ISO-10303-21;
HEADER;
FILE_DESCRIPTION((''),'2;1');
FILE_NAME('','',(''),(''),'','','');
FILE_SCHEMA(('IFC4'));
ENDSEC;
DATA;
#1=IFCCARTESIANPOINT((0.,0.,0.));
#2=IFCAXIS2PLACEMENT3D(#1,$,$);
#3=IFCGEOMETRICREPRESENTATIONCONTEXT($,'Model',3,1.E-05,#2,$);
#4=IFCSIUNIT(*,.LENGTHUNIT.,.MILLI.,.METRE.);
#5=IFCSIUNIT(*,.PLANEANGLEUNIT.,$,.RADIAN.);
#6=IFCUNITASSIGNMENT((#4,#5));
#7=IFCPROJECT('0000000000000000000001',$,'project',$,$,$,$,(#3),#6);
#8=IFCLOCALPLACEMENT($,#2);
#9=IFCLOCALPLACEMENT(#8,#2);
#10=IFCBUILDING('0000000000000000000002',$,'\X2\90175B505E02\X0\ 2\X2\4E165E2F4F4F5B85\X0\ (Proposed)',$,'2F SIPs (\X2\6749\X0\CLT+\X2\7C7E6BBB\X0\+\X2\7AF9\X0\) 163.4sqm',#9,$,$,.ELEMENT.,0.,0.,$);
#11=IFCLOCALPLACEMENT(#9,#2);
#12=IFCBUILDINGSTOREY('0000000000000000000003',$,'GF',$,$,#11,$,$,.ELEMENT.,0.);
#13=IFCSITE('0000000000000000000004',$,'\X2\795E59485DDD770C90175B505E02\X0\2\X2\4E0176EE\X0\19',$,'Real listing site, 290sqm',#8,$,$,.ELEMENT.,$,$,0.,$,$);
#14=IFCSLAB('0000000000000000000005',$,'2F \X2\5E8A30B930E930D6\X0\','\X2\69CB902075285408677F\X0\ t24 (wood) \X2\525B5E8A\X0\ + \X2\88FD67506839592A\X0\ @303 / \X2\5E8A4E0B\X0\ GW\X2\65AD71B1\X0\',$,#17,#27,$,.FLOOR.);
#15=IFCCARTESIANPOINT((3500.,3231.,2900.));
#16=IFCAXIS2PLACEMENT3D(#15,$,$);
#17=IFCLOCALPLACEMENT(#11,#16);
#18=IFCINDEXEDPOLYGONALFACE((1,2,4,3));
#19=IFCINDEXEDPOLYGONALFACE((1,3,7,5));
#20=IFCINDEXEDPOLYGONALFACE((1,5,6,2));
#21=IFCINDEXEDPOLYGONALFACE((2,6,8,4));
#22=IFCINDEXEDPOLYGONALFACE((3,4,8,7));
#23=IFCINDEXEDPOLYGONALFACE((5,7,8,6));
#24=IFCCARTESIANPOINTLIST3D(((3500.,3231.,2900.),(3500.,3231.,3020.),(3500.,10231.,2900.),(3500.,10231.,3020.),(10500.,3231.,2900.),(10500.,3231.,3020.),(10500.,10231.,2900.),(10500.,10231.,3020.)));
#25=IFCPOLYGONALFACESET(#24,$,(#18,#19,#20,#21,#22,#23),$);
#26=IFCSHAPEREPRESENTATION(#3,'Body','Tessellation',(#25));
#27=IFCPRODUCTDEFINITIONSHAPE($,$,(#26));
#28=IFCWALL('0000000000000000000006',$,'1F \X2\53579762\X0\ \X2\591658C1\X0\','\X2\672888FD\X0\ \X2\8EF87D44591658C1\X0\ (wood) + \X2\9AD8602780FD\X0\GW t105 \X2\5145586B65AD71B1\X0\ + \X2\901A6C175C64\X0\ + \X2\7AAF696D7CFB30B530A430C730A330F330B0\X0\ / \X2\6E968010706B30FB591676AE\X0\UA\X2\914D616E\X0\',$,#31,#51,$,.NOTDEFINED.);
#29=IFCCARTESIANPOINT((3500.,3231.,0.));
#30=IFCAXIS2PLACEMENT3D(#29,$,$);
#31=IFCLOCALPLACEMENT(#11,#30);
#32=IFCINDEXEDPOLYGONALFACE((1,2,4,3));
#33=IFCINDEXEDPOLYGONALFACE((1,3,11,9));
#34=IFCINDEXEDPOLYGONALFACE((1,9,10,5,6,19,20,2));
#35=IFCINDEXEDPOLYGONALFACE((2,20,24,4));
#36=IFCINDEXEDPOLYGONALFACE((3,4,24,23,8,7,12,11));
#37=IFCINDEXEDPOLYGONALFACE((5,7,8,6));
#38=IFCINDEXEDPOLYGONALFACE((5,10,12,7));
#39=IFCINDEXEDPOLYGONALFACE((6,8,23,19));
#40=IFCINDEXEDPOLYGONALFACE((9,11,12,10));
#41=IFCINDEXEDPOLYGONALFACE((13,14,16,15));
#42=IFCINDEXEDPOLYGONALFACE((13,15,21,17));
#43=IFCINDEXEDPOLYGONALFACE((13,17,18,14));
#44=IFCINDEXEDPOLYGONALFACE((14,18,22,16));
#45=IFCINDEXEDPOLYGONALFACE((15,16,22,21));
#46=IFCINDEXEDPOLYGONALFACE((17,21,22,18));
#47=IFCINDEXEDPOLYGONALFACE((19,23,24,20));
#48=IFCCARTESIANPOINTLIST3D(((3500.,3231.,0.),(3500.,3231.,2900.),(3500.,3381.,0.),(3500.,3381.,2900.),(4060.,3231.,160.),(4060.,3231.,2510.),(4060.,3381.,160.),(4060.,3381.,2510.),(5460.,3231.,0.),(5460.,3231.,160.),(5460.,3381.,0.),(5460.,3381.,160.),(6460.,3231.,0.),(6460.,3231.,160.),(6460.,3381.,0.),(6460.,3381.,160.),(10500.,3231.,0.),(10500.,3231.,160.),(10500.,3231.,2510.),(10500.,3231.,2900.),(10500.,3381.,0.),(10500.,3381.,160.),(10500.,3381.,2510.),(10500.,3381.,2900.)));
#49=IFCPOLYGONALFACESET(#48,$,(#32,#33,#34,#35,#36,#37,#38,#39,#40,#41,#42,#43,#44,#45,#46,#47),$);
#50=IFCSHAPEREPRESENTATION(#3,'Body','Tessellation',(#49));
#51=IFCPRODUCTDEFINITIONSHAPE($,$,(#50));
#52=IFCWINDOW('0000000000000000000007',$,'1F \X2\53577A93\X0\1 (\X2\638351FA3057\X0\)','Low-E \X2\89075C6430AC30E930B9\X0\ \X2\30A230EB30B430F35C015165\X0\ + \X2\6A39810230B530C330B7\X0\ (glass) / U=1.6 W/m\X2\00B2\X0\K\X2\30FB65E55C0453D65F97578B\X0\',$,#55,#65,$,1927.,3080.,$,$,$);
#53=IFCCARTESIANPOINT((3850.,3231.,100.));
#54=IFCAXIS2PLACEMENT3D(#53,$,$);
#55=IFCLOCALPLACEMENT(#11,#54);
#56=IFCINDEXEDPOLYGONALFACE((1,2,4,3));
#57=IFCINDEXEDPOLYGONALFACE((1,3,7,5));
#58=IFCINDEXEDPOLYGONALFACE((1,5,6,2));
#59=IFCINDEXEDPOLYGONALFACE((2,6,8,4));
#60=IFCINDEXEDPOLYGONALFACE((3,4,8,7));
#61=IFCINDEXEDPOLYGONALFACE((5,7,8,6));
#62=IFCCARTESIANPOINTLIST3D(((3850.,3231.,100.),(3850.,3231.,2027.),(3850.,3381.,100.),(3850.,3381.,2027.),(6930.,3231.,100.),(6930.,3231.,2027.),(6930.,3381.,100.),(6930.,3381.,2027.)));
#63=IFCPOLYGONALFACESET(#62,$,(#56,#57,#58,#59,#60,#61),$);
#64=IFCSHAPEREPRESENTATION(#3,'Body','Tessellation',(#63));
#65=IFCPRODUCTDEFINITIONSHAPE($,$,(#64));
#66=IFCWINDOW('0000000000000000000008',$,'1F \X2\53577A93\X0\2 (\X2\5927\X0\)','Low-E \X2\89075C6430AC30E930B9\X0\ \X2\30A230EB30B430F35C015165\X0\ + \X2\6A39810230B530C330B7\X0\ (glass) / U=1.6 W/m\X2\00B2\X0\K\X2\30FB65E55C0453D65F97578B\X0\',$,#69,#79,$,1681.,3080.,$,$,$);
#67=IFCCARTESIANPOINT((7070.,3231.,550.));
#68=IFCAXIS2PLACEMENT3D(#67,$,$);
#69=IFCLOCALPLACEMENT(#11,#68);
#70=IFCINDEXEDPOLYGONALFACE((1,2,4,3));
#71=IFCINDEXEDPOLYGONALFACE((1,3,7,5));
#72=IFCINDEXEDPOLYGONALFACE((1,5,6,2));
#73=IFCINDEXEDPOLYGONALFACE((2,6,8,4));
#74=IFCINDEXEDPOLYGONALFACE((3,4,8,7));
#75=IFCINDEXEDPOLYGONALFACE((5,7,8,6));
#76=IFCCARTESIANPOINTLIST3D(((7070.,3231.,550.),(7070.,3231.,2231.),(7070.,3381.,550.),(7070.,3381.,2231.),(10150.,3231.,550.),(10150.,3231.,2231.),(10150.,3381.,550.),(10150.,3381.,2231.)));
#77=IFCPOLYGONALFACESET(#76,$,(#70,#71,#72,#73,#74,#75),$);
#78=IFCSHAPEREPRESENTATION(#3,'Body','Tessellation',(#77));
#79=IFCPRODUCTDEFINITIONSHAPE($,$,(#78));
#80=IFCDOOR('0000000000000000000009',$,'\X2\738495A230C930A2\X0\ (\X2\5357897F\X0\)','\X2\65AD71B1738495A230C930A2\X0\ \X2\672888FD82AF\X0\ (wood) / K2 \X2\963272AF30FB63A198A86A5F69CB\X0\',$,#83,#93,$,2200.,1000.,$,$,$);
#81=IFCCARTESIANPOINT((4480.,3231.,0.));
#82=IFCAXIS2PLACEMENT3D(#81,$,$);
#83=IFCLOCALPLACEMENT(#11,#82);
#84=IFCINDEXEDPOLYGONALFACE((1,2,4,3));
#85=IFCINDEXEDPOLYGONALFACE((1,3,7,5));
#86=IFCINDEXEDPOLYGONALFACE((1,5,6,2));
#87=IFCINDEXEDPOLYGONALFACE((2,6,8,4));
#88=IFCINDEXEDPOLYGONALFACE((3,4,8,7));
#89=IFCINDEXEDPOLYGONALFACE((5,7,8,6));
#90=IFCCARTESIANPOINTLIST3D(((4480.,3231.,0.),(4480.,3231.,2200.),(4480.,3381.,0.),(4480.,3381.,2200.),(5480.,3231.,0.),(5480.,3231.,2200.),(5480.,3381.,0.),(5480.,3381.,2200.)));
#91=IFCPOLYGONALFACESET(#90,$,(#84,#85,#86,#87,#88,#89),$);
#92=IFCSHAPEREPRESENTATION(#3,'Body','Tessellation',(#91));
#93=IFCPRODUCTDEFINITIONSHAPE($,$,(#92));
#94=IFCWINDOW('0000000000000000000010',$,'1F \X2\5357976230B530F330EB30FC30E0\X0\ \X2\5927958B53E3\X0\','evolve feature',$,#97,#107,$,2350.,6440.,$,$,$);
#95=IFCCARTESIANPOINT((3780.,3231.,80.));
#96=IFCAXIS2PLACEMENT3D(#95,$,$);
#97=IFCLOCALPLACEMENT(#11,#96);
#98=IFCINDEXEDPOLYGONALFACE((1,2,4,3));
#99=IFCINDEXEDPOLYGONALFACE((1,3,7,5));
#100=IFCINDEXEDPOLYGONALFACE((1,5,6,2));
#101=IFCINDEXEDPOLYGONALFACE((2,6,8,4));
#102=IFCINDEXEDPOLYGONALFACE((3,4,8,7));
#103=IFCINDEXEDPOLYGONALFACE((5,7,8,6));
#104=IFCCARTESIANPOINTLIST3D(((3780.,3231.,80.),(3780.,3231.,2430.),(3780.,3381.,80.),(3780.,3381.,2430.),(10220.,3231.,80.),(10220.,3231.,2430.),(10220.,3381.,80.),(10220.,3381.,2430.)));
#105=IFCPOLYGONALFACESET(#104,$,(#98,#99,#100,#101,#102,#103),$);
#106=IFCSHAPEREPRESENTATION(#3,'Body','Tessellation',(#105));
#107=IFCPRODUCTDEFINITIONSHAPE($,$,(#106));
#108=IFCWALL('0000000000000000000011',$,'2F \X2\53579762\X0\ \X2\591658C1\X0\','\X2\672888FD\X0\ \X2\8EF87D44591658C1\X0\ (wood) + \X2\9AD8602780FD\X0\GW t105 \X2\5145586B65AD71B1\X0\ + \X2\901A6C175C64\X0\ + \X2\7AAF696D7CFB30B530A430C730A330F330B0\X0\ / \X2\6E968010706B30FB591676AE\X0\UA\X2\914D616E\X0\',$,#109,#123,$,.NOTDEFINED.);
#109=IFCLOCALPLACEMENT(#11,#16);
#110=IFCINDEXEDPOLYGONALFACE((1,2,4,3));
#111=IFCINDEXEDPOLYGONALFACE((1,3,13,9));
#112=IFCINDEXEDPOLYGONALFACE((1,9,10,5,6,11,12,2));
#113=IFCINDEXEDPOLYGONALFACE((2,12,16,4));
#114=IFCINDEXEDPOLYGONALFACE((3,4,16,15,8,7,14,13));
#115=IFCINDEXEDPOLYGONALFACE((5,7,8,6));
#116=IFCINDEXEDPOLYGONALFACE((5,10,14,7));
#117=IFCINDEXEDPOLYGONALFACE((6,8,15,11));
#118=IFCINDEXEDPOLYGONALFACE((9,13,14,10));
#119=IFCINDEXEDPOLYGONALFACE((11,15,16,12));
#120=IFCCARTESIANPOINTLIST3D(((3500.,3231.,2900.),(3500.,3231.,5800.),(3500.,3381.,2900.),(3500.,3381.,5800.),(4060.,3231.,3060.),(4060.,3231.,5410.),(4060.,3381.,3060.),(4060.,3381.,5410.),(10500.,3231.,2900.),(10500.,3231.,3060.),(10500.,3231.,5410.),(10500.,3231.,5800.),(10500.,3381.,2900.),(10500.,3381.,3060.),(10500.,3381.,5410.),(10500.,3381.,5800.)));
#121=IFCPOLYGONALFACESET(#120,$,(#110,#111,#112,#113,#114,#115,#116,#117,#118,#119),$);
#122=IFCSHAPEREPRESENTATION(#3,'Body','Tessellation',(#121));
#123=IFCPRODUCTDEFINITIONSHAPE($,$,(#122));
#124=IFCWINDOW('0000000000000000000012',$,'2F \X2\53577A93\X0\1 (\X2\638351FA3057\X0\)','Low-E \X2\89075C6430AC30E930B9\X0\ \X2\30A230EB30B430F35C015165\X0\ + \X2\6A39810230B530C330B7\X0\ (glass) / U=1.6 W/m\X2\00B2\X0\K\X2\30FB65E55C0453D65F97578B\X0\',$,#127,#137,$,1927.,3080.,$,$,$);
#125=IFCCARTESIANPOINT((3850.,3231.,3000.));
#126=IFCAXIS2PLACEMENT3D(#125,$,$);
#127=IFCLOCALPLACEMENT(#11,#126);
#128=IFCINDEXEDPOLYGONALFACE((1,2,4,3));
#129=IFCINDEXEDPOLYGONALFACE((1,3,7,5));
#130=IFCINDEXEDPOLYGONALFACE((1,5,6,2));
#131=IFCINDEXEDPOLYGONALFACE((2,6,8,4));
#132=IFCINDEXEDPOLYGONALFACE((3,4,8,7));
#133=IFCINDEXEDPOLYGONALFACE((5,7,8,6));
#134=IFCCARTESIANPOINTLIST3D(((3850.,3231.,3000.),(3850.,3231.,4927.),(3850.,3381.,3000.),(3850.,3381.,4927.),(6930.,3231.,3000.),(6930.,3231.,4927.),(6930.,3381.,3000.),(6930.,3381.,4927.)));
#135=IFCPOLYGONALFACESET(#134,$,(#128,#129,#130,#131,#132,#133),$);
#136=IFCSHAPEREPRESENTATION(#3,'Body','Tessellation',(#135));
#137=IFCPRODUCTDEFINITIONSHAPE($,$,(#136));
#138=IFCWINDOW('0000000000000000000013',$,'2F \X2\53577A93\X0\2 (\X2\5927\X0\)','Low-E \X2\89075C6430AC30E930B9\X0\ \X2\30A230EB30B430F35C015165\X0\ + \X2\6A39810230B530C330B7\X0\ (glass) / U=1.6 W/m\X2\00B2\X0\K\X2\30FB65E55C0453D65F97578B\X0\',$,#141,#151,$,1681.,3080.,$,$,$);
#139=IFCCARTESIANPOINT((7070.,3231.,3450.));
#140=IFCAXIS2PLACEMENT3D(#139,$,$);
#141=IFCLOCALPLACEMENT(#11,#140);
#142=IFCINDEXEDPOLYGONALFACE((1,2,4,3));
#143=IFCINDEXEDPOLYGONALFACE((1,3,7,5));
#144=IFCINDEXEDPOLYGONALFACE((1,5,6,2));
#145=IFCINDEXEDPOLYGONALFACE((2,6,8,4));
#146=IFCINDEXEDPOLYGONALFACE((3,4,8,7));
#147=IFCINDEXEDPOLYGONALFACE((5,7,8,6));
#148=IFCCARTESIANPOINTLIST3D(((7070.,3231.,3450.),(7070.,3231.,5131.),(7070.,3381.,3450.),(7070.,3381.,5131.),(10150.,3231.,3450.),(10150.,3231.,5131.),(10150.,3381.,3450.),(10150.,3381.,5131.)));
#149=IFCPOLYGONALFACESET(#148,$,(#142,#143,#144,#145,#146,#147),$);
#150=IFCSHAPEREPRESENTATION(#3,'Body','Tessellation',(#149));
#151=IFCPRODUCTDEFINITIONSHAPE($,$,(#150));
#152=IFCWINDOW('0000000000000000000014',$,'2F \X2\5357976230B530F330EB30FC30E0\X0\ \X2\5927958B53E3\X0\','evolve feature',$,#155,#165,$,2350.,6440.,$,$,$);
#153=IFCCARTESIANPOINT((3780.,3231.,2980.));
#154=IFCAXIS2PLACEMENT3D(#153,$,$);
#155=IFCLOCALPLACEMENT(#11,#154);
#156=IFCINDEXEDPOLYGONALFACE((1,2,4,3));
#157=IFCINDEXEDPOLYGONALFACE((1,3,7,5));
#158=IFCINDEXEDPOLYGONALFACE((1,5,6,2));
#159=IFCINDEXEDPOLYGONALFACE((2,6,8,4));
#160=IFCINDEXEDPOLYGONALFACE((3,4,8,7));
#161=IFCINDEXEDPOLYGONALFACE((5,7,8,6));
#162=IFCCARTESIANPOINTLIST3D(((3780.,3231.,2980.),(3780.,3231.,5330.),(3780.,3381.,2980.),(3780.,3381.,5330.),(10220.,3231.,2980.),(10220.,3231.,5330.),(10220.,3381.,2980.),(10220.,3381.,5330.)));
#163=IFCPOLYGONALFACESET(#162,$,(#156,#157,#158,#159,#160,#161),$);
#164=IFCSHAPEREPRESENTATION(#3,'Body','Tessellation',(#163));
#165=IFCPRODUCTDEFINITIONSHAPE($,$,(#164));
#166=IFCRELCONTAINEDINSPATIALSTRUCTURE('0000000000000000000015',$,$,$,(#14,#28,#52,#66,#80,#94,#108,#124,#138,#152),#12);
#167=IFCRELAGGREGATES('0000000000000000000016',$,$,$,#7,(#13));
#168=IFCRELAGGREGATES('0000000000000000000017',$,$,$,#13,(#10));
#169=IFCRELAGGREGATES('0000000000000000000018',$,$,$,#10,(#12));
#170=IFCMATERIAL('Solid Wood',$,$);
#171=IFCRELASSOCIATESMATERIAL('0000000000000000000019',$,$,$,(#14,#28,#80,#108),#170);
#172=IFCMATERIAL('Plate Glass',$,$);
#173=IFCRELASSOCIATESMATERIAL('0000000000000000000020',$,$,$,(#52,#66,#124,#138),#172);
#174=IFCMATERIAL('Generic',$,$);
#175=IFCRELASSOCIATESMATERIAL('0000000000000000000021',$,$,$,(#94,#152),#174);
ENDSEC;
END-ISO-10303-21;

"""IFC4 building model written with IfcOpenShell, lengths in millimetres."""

from ifc_helpers import new_model, si_unit, frame, frame_2d, origin, place, context, project, spatial, rectangle, extrude, material, element, fill, save


model = new_model("IFC4")

# Units and contexts
model_context = context("Model", 3, precision=1e-05, world=origin())
ifc_project = project(units=[si_unit("LENGTHUNIT", "METRE", prefix="MILLI"), si_unit("PLANEANGLEUNIT", "RADIAN")], contexts=[model_context])

# Site, building, storey
site_placement = place(None, origin())
site = spatial("IfcSite", under=ifc_project, at=site_placement, Name="神奈川県逗子市2丁目19", ObjectType="Real listing site, 290sqm", CompositionType="ELEMENT", RefElevation=0.0)
building_placement = place(site_placement, origin())
building = spatial("IfcBuilding", under=site, at=building_placement, Name="逗子市 2世帯住宅 (Proposed)", ObjectType="2F SIPs (杉CLT+籾殻+竹) 163.4sqm", CompositionType="ELEMENT", ElevationOfRefHeight=0.0, ElevationOfTerrain=0.0)
storey_placement = place(building_placement, origin())
storey = spatial("IfcBuildingStorey", under=building, at=storey_placement, Name="GF", CompositionType="ELEMENT", Elevation=0.0)

# Slab
ifc_material_1 = material(Name="Solid Wood")
slab_1_placement = place(storey_placement, frame((3500.0, 3231.0, 2900.0)))
element("IfcSlab", 1, at=slab_1_placement, inside=storey, material=ifc_material_1, Name="2F 床スラブ", Description="構造用合板 t24 (wood) 剛床 + 製材根太 @303 / 床下 GW断熱", PredefinedType="FLOOR", context=model_context, shape_type="SweptSolid", body=[
    extrude(rectangle(XDim=7000.0, YDim=7000.0, at=frame_2d((3500.0, 3500.0))), frame((3500.0, 3231.0, 2900.0)), (0.0, 0.0, 1.0), 120.0),
])
ifc_material_2 = material(Name="Generic")

# Wall, openings, windows, door
wall_1_placement = place(storey_placement, frame((3500.0, 3231.0, 0.0)))
wall_1 = element("IfcWall", 2, at=wall_1_placement, inside=storey, material=ifc_material_1, Name="1F 南面 外壁", Description="木製 軸組外壁 (wood) + 高性能GW t105 充填断熱 + 通気層 + 窯業系サイディング / 準耐火・外皮UA配慮", PredefinedType="NOTDEFINED", context=model_context, shape_type="SweptSolid", body=[
    extrude(rectangle(XDim=7000.0, YDim=150.0, at=frame_2d((3500.0, 75.0))), frame((3500.0, 3231.0, 0.0)), (0.0, 0.0, 1.0), 2900.0),
])
opening_1_placement = place(storey_placement, frame((3850.0, 3231.0, 100.0)))
opening_1 = element("IfcOpeningElement", 3, at=opening_1_placement, cuts=wall_1, PredefinedType="NOTDEFINED", context=model_context, shape_type="SweptSolid", body=[
    extrude(rectangle(XDim=3080.0, YDim=150.0, at=frame_2d((1540.0, 75.0))), frame((3850.0, 3231.0, 100.0)), (0.0, 0.0, 1.0), 1927.0),
])
opening_2_placement = place(storey_placement, frame((7070.0, 3231.0, 550.0)))
opening_2 = element("IfcOpeningElement", 4, at=opening_2_placement, cuts=wall_1, PredefinedType="NOTDEFINED", context=model_context, shape_type="SweptSolid", body=[
    extrude(rectangle(XDim=3080.0, YDim=150.0, at=frame_2d((1540.0, 75.0))), frame((7070.0, 3231.0, 550.0)), (0.0, 0.0, 1.0), 1681.0),
])
opening_3_placement = place(storey_placement, frame((4480.0, 3231.0, 0.0)))
opening_3 = element("IfcOpeningElement", 5, at=opening_3_placement, cuts=wall_1, PredefinedType="NOTDEFINED", context=model_context, shape_type="SweptSolid", body=[
    extrude(rectangle(XDim=1000.0, YDim=150.0, at=frame_2d((500.0, 75.0))), frame((4480.0, 3231.0, 0.0)), (0.0, 0.0, 1.0), 2200.0),
])
opening_4_placement = place(storey_placement, frame((3780.0, 3231.0, 80.0)))
opening_4 = element("IfcOpeningElement", 6, at=opening_4_placement, cuts=wall_1, PredefinedType="NOTDEFINED", context=model_context, shape_type="SweptSolid", body=[
    extrude(rectangle(XDim=6440.0, YDim=150.0, at=frame_2d((3220.0, 75.0))), frame((3780.0, 3231.0, 80.0)), (0.0, 0.0, 1.0), 2350.0),
])
ifc_material_3 = material(Name="Plate Glass")
window_1_placement = place(storey_placement, frame((3850.0, 3231.0, 100.0)))
window_1 = element("IfcWindow", 7, at=window_1_placement, inside=storey, material=ifc_material_3, Name="1F 南窓1 (掃出し)", Description="Low-E 複層ガラス アルゴン封入 + 樹脂サッシ (glass) / U=1.6 W/m²K・日射取得型", OverallHeight=1927.0, OverallWidth=3080.0, context=model_context, shape_type="SweptSolid", body=[
    extrude(rectangle(XDim=3080.0, YDim=150.0, at=frame_2d((1540.0, 75.0))), frame((3850.0, 3231.0, 100.0)), (0.0, 0.0, 1.0), 1927.0),
])
fill(opening_1, window_1)
window_2_placement = place(storey_placement, frame((7070.0, 3231.0, 550.0)))
window_2 = element("IfcWindow", 8, at=window_2_placement, inside=storey, material=ifc_material_3, Name="1F 南窓2 (大)", Description="Low-E 複層ガラス アルゴン封入 + 樹脂サッシ (glass) / U=1.6 W/m²K・日射取得型", OverallHeight=1681.0, OverallWidth=3080.0, context=model_context, shape_type="SweptSolid", body=[
    extrude(rectangle(XDim=3080.0, YDim=150.0, at=frame_2d((1540.0, 75.0))), frame((7070.0, 3231.0, 550.0)), (0.0, 0.0, 1.0), 1681.0),
])
fill(opening_2, window_2)
door_placement = place(storey_placement, frame((4480.0, 3231.0, 0.0)))
door = element("IfcDoor", 9, at=door_placement, inside=storey, material=ifc_material_1, Name="玄関ドア (南西)", Description="断熱玄関ドア 木製芯 (wood) / K2 防犯・採風機構", OverallHeight=2200.0, OverallWidth=1000.0, context=model_context, shape_type="SweptSolid", body=[
    extrude(rectangle(XDim=1000.0, YDim=150.0, at=frame_2d((500.0, 75.0))), frame((4480.0, 3231.0, 0.0)), (0.0, 0.0, 1.0), 2200.0),
])
fill(opening_3, door)
window_3_placement = place(storey_placement, frame((3780.0, 3231.0, 80.0)))
window_3 = element("IfcWindow", 10, at=window_3_placement, inside=storey, material=ifc_material_2, Name="1F 南面サンルーム 大開口", Description="evolve feature", OverallHeight=2350.0, OverallWidth=6440.0, context=model_context, shape_type="SweptSolid", body=[
    extrude(rectangle(XDim=6440.0, YDim=150.0, at=frame_2d((3220.0, 75.0))), frame((3780.0, 3231.0, 80.0)), (0.0, 0.0, 1.0), 2350.0),
])
fill(opening_4, window_3)

# Wall, openings, windows
wall_2_placement = place(storey_placement, frame((3500.0, 3231.0, 2900.0)))
wall_2 = element("IfcWall", 11, at=wall_2_placement, inside=storey, material=ifc_material_1, Name="2F 南面 外壁", Description="木製 軸組外壁 (wood) + 高性能GW t105 充填断熱 + 通気層 + 窯業系サイディング / 準耐火・外皮UA配慮", PredefinedType="NOTDEFINED", context=model_context, shape_type="SweptSolid", body=[
    extrude(rectangle(XDim=7000.0, YDim=150.0, at=frame_2d((3500.0, 75.0))), frame((3500.0, 3231.0, 2900.0)), (0.0, 0.0, 1.0), 2900.0),
])
opening_5_placement = place(storey_placement, frame((3850.0, 3231.0, 3000.0)))
opening_5 = element("IfcOpeningElement", 12, at=opening_5_placement, cuts=wall_2, PredefinedType="NOTDEFINED", context=model_context, shape_type="SweptSolid", body=[
    extrude(rectangle(XDim=3080.0, YDim=150.0, at=frame_2d((1540.0, 75.0))), frame((3850.0, 3231.0, 3000.0)), (0.0, 0.0, 1.0), 1927.0),
])
opening_6_placement = place(storey_placement, frame((7070.0, 3231.0, 3450.0)))
opening_6 = element("IfcOpeningElement", 13, at=opening_6_placement, cuts=wall_2, PredefinedType="NOTDEFINED", context=model_context, shape_type="SweptSolid", body=[
    extrude(rectangle(XDim=3080.0, YDim=150.0, at=frame_2d((1540.0, 75.0))), frame((7070.0, 3231.0, 3450.0)), (0.0, 0.0, 1.0), 1681.0),
])
opening_7_placement = place(storey_placement, frame((3780.0, 3231.0, 2980.0)))
opening_7 = element("IfcOpeningElement", 14, at=opening_7_placement, cuts=wall_2, PredefinedType="NOTDEFINED", context=model_context, shape_type="SweptSolid", body=[
    extrude(rectangle(XDim=6440.0, YDim=150.0, at=frame_2d((3220.0, 75.0))), frame((3780.0, 3231.0, 2980.0)), (0.0, 0.0, 1.0), 2350.0),
])
window_4_placement = place(storey_placement, frame((3850.0, 3231.0, 3000.0)))
window_4 = element("IfcWindow", 15, at=window_4_placement, inside=storey, material=ifc_material_3, Name="2F 南窓1 (掃出し)", Description="Low-E 複層ガラス アルゴン封入 + 樹脂サッシ (glass) / U=1.6 W/m²K・日射取得型", OverallHeight=1927.0, OverallWidth=3080.0, context=model_context, shape_type="SweptSolid", body=[
    extrude(rectangle(XDim=3080.0, YDim=150.0, at=frame_2d((1540.0, 75.0))), frame((3850.0, 3231.0, 3000.0)), (0.0, 0.0, 1.0), 1927.0),
])
fill(opening_5, window_4)
window_5_placement = place(storey_placement, frame((7070.0, 3231.0, 3450.0)))
window_5 = element("IfcWindow", 16, at=window_5_placement, inside=storey, material=ifc_material_3, Name="2F 南窓2 (大)", Description="Low-E 複層ガラス アルゴン封入 + 樹脂サッシ (glass) / U=1.6 W/m²K・日射取得型", OverallHeight=1681.0, OverallWidth=3080.0, context=model_context, shape_type="SweptSolid", body=[
    extrude(rectangle(XDim=3080.0, YDim=150.0, at=frame_2d((1540.0, 75.0))), frame((7070.0, 3231.0, 3450.0)), (0.0, 0.0, 1.0), 1681.0),
])
fill(opening_6, window_5)
window_6_placement = place(storey_placement, frame((3780.0, 3231.0, 2980.0)))
window_6 = element("IfcWindow", 17, at=window_6_placement, inside=storey, material=ifc_material_2, Name="2F 南面サンルーム 大開口", Description="evolve feature", OverallHeight=2350.0, OverallWidth=6440.0, context=model_context, shape_type="SweptSolid", body=[
    extrude(rectangle(XDim=6440.0, YDim=150.0, at=frame_2d((3220.0, 75.0))), frame((3780.0, 3231.0, 2980.0)), (0.0, 0.0, 1.0), 2350.0),
])
fill(opening_7, window_6)

save(model, "model.ifc")
